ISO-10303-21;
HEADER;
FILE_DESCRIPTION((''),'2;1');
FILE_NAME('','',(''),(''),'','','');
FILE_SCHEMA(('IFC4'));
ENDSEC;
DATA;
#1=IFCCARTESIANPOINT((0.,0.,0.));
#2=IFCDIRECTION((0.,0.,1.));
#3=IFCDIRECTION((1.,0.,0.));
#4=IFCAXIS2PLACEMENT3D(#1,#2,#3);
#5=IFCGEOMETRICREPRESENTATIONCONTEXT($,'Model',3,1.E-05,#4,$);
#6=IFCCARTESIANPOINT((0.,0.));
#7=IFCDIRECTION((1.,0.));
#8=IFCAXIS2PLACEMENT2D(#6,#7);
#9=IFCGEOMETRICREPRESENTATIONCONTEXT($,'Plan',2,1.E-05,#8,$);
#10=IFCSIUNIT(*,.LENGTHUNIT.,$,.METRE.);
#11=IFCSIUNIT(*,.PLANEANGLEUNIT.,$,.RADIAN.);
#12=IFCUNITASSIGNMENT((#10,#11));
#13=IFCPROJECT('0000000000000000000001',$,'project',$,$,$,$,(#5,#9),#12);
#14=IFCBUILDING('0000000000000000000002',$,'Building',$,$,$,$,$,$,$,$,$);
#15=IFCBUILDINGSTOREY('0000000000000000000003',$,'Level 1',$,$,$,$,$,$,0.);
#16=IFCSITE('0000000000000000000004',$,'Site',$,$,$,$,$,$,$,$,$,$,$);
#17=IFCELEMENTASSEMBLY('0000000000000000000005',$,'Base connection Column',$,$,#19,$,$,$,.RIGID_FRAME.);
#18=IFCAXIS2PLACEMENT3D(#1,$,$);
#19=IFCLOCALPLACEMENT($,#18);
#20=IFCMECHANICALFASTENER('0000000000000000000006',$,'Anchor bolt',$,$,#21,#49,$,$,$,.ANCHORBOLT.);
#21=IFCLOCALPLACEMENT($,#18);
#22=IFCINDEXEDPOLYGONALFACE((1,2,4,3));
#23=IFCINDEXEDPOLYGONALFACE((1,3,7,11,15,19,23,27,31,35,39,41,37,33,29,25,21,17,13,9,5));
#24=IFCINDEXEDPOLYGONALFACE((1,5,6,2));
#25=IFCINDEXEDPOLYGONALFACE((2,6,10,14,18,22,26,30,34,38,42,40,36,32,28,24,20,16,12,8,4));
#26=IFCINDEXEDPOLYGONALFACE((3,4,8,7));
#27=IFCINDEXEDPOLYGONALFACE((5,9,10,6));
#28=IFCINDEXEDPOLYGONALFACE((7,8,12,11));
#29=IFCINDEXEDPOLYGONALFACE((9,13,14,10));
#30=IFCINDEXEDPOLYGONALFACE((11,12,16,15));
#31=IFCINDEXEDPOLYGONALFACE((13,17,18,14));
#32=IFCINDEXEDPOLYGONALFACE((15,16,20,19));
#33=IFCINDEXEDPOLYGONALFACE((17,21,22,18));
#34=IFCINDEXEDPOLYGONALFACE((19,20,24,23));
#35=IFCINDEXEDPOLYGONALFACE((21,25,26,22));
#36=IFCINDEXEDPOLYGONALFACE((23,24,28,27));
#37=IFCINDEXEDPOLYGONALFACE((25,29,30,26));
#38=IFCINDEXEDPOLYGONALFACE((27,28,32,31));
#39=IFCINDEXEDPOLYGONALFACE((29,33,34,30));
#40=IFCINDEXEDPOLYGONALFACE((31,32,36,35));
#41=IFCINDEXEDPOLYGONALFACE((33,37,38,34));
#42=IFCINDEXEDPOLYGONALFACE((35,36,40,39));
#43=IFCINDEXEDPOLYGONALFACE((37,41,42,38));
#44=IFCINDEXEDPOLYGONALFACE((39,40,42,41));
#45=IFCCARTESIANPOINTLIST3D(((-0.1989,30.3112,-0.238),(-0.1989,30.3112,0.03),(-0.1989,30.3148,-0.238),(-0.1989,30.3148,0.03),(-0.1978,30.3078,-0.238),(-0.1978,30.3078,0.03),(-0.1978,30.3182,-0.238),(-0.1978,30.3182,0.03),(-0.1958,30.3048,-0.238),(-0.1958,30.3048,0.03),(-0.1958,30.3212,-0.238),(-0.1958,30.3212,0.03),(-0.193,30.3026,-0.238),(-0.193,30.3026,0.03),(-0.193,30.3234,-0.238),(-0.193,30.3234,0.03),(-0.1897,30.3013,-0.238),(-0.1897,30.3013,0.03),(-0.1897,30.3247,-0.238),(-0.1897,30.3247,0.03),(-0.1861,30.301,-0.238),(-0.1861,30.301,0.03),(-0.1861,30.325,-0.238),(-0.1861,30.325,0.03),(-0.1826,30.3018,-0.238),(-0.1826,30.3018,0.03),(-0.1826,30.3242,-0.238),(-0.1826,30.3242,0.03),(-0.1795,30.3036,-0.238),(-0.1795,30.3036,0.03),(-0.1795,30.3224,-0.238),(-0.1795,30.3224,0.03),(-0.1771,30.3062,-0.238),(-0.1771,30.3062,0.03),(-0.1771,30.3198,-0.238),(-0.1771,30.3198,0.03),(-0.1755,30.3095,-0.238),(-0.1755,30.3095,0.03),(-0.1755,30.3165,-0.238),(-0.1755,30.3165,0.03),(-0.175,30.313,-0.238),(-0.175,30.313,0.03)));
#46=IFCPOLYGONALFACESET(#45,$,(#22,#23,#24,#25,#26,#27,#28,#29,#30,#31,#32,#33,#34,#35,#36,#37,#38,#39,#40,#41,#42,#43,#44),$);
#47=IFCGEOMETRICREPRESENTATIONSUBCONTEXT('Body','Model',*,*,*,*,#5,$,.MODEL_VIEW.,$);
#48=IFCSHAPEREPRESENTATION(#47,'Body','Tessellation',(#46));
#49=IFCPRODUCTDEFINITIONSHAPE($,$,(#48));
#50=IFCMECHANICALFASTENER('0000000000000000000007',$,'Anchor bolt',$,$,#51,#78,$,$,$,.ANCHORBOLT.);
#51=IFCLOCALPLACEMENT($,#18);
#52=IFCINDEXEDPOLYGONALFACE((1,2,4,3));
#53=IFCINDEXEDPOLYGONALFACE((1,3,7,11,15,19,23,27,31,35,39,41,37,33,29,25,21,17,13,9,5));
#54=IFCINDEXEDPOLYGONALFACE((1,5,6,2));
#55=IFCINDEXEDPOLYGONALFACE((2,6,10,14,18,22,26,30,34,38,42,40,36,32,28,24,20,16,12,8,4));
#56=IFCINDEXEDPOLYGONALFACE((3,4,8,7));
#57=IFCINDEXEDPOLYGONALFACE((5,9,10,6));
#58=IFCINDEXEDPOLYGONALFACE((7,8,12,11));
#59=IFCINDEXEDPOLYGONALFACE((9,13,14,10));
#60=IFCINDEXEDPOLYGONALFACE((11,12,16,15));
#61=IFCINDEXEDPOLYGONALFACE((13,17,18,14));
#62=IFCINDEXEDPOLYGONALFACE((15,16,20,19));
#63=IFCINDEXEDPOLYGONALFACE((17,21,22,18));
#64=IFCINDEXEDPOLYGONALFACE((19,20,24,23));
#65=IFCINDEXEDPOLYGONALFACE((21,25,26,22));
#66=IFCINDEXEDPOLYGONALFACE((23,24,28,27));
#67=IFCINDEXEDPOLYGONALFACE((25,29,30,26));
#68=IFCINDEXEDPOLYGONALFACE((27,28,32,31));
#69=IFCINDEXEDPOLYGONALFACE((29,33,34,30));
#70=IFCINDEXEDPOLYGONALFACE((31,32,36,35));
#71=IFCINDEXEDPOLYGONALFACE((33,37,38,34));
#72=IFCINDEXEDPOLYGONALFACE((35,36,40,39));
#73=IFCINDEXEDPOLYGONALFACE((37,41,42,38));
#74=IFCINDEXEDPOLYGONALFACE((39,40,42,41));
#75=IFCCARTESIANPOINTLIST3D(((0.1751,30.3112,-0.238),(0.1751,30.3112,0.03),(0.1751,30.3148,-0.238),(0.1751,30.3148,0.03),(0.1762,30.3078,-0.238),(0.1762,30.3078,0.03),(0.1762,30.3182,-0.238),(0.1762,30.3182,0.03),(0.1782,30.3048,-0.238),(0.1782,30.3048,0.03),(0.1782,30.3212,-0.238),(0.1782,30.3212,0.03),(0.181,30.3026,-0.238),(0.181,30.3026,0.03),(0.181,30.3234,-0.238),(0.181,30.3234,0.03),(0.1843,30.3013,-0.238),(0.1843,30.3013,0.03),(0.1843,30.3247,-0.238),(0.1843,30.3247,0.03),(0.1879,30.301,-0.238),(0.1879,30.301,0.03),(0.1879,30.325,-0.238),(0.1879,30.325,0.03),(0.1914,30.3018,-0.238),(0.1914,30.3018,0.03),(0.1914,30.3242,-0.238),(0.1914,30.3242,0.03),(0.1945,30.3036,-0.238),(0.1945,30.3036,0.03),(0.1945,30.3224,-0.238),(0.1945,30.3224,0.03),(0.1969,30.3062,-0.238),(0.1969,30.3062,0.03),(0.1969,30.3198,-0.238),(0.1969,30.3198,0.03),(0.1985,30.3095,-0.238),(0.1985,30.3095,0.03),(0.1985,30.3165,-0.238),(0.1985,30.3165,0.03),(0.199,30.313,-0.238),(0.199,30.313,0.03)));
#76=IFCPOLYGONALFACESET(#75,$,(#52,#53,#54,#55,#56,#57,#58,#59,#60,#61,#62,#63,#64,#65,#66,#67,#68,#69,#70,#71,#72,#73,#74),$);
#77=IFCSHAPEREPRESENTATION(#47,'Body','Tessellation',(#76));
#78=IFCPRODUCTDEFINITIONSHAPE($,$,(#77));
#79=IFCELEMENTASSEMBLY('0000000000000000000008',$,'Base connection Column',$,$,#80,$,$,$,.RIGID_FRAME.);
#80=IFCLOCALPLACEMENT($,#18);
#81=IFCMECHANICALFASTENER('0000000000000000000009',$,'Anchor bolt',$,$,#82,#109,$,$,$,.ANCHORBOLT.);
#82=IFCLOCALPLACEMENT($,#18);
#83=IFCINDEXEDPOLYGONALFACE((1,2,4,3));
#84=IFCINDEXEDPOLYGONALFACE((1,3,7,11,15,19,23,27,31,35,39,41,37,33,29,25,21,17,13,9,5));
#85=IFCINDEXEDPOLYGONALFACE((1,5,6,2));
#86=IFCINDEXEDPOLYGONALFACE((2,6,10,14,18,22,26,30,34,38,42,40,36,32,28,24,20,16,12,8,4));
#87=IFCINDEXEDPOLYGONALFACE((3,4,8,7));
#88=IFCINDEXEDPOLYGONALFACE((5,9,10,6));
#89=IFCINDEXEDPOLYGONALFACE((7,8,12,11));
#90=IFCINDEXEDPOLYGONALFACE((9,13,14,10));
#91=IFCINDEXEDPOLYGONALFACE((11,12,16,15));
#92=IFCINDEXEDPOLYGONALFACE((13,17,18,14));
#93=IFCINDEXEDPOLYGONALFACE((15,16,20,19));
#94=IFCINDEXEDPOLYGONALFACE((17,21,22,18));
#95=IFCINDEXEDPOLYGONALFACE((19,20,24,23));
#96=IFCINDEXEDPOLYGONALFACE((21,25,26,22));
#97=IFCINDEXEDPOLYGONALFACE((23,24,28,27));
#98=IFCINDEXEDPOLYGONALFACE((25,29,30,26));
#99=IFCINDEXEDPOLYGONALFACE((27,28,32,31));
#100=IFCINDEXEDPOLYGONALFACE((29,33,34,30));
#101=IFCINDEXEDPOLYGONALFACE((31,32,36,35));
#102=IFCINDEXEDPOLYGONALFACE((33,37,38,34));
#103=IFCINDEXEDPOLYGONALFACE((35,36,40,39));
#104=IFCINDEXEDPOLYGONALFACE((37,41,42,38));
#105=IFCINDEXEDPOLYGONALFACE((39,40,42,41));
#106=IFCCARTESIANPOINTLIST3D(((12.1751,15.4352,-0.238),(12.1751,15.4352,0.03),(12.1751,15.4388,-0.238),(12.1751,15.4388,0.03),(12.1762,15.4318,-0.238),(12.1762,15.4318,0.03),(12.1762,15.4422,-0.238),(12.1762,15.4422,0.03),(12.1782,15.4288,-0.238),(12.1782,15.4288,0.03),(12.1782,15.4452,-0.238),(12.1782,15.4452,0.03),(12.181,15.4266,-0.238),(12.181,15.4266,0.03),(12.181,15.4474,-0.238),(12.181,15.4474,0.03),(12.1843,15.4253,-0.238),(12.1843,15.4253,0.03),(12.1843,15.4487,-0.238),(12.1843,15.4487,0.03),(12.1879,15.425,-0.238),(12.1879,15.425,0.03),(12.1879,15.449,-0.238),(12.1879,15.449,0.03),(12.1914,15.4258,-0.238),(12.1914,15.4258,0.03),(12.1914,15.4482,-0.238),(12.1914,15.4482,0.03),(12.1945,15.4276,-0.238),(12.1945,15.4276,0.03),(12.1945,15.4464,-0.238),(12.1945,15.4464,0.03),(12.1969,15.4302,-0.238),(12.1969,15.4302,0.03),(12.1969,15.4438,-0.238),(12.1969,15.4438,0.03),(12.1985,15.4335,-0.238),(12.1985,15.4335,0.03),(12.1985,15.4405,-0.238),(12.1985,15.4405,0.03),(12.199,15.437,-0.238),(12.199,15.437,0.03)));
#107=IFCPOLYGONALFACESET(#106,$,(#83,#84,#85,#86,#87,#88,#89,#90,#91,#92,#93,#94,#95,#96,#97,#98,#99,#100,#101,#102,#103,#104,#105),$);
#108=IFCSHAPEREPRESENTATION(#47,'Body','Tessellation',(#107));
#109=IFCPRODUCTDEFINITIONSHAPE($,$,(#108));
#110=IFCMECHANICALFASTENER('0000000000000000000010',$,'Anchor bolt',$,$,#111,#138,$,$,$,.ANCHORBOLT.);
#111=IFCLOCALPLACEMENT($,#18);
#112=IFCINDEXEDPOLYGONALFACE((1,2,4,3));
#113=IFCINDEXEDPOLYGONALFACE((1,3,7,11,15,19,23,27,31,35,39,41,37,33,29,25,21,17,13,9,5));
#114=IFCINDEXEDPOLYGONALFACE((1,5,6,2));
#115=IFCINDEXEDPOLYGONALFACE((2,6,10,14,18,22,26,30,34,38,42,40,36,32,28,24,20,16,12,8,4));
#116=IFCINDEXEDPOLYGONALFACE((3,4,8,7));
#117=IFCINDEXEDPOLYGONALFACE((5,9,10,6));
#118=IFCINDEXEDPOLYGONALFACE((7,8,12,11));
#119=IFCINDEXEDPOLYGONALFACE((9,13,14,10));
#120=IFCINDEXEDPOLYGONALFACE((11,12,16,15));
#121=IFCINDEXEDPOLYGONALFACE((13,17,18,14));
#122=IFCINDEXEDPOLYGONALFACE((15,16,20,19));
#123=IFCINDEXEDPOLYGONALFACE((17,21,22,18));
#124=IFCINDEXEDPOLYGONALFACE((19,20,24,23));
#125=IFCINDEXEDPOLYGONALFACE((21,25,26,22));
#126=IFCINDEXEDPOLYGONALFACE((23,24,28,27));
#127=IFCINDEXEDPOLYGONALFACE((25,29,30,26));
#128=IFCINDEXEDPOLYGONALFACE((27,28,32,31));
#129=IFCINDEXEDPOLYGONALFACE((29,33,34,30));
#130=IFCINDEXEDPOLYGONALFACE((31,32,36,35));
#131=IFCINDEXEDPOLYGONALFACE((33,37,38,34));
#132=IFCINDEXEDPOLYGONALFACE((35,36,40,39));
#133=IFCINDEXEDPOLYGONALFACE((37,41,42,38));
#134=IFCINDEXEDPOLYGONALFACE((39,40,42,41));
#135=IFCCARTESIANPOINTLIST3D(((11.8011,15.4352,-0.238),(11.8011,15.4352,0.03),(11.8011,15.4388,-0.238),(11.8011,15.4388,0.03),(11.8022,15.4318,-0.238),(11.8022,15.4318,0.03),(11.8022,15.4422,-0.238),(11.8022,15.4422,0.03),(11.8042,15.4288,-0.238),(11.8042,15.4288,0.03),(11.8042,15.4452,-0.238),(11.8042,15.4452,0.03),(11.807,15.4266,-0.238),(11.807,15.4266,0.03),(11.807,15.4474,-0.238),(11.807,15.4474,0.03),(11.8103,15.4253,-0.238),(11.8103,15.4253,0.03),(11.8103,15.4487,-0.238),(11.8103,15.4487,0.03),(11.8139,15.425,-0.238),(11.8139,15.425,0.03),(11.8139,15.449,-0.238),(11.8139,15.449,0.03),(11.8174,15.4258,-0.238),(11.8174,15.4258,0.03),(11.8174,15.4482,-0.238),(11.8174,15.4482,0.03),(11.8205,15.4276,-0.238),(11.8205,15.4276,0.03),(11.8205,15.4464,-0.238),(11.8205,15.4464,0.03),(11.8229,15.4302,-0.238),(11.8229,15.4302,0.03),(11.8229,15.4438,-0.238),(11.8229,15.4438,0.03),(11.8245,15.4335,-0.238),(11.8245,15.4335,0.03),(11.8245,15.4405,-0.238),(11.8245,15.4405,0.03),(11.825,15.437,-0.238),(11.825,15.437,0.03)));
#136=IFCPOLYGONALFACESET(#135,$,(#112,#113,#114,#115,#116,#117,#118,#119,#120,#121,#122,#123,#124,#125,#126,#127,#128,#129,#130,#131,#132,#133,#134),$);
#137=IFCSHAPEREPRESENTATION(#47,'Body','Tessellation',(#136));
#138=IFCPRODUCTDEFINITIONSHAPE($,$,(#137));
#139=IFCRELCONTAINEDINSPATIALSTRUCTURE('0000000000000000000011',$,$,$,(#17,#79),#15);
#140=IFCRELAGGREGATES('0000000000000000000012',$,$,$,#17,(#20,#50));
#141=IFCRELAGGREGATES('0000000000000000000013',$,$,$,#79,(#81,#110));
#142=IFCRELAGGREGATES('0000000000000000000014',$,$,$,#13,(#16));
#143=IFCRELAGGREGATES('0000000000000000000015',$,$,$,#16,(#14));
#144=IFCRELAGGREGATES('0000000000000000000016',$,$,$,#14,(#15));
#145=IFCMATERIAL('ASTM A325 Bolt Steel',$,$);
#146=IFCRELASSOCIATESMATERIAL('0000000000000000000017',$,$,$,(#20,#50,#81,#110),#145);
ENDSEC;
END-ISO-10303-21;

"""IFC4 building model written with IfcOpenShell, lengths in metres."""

from ifc_helpers import new_model, si_unit, frame, origin_with_axes, origin_2d, origin_2d_with_axis, place, context, subcontext, project, spatial, circle, extrude, material, element, aggregate, save


model = new_model("IFC4")

# Units and contexts
model_context = context("Model", 3, precision=1e-05, world=origin_with_axes())
plan_context = context("Plan", 2, precision=1e-05, world=origin_2d_with_axis())
body_context = subcontext(model_context, "Body", "Model", "MODEL_VIEW")
ifc_project = project(units=[si_unit("LENGTHUNIT", "METRE"), si_unit("PLANEANGLEUNIT", "RADIAN")], contexts=[model_context, plan_context])

# Site, building, storey
site = spatial("IfcSite", under=ifc_project, Name="Site")
building = spatial("IfcBuilding", under=site, Name="Building")
storey = spatial("IfcBuildingStorey", under=building, Name="Level 1", Elevation=0.0)

# Element assemblies, mechanical fasteners
ifc_material_1 = material(Name="ASTM A325 Bolt Steel")
assembly_1 = element("IfcElementAssembly", 1, inside=storey, Name="Base connection Column", PredefinedType="RIGID_FRAME")
mechanical_fastener_1_placement = place(None, frame((-0.187, 30.313, -0.238), z_axis=(0.0, 0.0, 1.0), x_axis=(1.0, 0.0, 0.0)))
mechanical_fastener_1 = element("IfcMechanicalFastener", 2, at=mechanical_fastener_1_placement, material=ifc_material_1, Name="Anchor bolt", PredefinedType="ANCHORBOLT", context=body_context, shape_type="SweptSolid", body=[
    extrude(circle(Radius=0.012, at=origin_2d()), origin_with_axes(), (0.0, 0.0, 1.0), 0.268),
])
mechanical_fastener_2_placement = place(None, frame((0.187, 30.313, -0.238), z_axis=(0.0, 0.0, 1.0), x_axis=(1.0, 0.0, 0.0)))
mechanical_fastener_2 = element("IfcMechanicalFastener", 3, at=mechanical_fastener_2_placement, material=ifc_material_1, Name="Anchor bolt", PredefinedType="ANCHORBOLT", context=body_context, shape_type="SweptSolid", body=[
    extrude(circle(Radius=0.012, at=origin_2d()), origin_with_axes(), (0.0, 0.0, 1.0), 0.268),
])
aggregate(assembly_1, [mechanical_fastener_1, mechanical_fastener_2])
assembly_2 = element("IfcElementAssembly", 4, inside=storey, Name="Base connection Column", PredefinedType="RIGID_FRAME")
mechanical_fastener_3_placement = place(None, frame((12.187, 15.437, -0.238), z_axis=(0.0, 0.0, 1.0), x_axis=(1.0, 0.0, 0.0)))
mechanical_fastener_3 = element("IfcMechanicalFastener", 5, at=mechanical_fastener_3_placement, material=ifc_material_1, Name="Anchor bolt", PredefinedType="ANCHORBOLT", context=body_context, shape_type="SweptSolid", body=[
    extrude(circle(Radius=0.012, at=origin_2d()), origin_with_axes(), (0.0, 0.0, 1.0), 0.268),
])
mechanical_fastener_4_placement = place(None, frame((11.813, 15.437, -0.238), z_axis=(0.0, 0.0, 1.0), x_axis=(1.0, 0.0, 0.0)))
mechanical_fastener_4 = element("IfcMechanicalFastener", 6, at=mechanical_fastener_4_placement, material=ifc_material_1, Name="Anchor bolt", PredefinedType="ANCHORBOLT", context=body_context, shape_type="SweptSolid", body=[
    extrude(circle(Radius=0.012, at=origin_2d()), origin_with_axes(), (0.0, 0.0, 1.0), 0.268),
])
aggregate(assembly_2, [mechanical_fastener_3, mechanical_fastener_4])

save(model, "model.ifc")
